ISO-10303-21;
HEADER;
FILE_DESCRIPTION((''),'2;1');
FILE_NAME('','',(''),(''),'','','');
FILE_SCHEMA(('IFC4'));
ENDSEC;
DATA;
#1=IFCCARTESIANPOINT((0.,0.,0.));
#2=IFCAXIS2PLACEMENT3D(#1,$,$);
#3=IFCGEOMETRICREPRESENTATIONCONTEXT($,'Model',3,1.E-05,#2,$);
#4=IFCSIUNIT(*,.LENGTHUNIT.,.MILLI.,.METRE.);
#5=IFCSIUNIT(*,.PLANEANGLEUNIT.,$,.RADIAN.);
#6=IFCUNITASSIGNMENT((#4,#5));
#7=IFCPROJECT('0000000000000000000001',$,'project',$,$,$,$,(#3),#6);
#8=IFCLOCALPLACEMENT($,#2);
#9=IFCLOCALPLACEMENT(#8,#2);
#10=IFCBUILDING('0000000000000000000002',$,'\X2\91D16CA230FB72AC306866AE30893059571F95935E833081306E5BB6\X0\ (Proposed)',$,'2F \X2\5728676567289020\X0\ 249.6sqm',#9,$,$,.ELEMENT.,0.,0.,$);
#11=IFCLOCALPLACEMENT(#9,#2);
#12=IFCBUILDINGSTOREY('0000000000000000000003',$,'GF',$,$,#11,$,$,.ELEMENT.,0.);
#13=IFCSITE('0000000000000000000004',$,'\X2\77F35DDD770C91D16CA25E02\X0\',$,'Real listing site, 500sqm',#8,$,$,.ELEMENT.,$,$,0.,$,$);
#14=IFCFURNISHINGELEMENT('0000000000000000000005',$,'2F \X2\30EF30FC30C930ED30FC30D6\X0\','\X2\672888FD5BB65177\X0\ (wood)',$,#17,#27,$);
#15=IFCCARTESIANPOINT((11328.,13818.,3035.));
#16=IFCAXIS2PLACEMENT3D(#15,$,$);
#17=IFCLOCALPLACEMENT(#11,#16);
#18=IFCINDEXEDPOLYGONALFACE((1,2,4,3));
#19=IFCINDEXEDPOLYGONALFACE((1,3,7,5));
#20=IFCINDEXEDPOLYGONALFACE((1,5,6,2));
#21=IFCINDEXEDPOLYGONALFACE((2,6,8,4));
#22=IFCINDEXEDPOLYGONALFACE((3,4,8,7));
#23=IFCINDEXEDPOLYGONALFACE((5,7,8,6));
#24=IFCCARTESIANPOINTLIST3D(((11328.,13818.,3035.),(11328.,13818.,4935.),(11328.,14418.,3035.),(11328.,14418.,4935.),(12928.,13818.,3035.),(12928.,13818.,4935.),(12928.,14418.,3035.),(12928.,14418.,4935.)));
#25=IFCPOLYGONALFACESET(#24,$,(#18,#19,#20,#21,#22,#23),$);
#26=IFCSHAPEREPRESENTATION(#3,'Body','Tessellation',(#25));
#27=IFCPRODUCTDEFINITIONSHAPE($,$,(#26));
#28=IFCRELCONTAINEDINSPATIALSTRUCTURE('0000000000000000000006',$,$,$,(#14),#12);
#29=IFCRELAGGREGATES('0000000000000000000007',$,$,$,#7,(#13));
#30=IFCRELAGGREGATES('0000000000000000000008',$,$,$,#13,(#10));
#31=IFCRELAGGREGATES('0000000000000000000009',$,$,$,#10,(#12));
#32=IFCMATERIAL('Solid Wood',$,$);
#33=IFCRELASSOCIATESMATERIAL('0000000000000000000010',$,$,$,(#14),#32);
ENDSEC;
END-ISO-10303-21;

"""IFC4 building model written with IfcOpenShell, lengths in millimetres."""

from ifc_helpers import new_model, si_unit, frame, frame_2d, origin, place, context, project, spatial, rectangle, extrude, material, element, save


model = new_model("IFC4")

# Units and contexts
model_context = context("Model", 3, precision=1e-05, world=origin())
ifc_project = project(units=[si_unit("LENGTHUNIT", "METRE", prefix="MILLI"), si_unit("PLANEANGLEUNIT", "RADIAN")], contexts=[model_context])

# Site, building, storey
site_placement = place(None, origin())
site = spatial("IfcSite", under=ifc_project, at=site_placement, Name="石川県金沢市", ObjectType="Real listing site, 500sqm", CompositionType="ELEMENT", RefElevation=0.0)
building_placement = place(site_placement, origin())
building = spatial("IfcBuilding", under=site, at=building_placement, Name="金沢・犬と暮らす土間広めの家 (Proposed)", ObjectType="2F 在来木造 249.6sqm", CompositionType="ELEMENT", ElevationOfRefHeight=0.0, ElevationOfTerrain=0.0)
storey_placement = place(building_placement, origin())
storey = spatial("IfcBuildingStorey", under=building, at=storey_placement, Name="GF", CompositionType="ELEMENT", Elevation=0.0)

# Shared definitions
ifc_material_1 = material(Name="Solid Wood")

# Furnishing element
furnishing_1_placement = place(storey_placement, frame((11328.0, 13818.0, 3035.0)))
element("IfcFurnishingElement", 1, at=furnishing_1_placement, inside=storey, material=ifc_material_1, Name="2F ワードローブ", Description="木製家具 (wood)", context=model_context, shape_type="SweptSolid", body=[
    extrude(rectangle(XDim=1600.0, YDim=600.0, at=frame_2d((800.0, 300.0))), frame((11328.0, 13818.0, 3035.0)), (0.0, 0.0, 1.0), 1900.0),
])

save(model, "model.ifc")
